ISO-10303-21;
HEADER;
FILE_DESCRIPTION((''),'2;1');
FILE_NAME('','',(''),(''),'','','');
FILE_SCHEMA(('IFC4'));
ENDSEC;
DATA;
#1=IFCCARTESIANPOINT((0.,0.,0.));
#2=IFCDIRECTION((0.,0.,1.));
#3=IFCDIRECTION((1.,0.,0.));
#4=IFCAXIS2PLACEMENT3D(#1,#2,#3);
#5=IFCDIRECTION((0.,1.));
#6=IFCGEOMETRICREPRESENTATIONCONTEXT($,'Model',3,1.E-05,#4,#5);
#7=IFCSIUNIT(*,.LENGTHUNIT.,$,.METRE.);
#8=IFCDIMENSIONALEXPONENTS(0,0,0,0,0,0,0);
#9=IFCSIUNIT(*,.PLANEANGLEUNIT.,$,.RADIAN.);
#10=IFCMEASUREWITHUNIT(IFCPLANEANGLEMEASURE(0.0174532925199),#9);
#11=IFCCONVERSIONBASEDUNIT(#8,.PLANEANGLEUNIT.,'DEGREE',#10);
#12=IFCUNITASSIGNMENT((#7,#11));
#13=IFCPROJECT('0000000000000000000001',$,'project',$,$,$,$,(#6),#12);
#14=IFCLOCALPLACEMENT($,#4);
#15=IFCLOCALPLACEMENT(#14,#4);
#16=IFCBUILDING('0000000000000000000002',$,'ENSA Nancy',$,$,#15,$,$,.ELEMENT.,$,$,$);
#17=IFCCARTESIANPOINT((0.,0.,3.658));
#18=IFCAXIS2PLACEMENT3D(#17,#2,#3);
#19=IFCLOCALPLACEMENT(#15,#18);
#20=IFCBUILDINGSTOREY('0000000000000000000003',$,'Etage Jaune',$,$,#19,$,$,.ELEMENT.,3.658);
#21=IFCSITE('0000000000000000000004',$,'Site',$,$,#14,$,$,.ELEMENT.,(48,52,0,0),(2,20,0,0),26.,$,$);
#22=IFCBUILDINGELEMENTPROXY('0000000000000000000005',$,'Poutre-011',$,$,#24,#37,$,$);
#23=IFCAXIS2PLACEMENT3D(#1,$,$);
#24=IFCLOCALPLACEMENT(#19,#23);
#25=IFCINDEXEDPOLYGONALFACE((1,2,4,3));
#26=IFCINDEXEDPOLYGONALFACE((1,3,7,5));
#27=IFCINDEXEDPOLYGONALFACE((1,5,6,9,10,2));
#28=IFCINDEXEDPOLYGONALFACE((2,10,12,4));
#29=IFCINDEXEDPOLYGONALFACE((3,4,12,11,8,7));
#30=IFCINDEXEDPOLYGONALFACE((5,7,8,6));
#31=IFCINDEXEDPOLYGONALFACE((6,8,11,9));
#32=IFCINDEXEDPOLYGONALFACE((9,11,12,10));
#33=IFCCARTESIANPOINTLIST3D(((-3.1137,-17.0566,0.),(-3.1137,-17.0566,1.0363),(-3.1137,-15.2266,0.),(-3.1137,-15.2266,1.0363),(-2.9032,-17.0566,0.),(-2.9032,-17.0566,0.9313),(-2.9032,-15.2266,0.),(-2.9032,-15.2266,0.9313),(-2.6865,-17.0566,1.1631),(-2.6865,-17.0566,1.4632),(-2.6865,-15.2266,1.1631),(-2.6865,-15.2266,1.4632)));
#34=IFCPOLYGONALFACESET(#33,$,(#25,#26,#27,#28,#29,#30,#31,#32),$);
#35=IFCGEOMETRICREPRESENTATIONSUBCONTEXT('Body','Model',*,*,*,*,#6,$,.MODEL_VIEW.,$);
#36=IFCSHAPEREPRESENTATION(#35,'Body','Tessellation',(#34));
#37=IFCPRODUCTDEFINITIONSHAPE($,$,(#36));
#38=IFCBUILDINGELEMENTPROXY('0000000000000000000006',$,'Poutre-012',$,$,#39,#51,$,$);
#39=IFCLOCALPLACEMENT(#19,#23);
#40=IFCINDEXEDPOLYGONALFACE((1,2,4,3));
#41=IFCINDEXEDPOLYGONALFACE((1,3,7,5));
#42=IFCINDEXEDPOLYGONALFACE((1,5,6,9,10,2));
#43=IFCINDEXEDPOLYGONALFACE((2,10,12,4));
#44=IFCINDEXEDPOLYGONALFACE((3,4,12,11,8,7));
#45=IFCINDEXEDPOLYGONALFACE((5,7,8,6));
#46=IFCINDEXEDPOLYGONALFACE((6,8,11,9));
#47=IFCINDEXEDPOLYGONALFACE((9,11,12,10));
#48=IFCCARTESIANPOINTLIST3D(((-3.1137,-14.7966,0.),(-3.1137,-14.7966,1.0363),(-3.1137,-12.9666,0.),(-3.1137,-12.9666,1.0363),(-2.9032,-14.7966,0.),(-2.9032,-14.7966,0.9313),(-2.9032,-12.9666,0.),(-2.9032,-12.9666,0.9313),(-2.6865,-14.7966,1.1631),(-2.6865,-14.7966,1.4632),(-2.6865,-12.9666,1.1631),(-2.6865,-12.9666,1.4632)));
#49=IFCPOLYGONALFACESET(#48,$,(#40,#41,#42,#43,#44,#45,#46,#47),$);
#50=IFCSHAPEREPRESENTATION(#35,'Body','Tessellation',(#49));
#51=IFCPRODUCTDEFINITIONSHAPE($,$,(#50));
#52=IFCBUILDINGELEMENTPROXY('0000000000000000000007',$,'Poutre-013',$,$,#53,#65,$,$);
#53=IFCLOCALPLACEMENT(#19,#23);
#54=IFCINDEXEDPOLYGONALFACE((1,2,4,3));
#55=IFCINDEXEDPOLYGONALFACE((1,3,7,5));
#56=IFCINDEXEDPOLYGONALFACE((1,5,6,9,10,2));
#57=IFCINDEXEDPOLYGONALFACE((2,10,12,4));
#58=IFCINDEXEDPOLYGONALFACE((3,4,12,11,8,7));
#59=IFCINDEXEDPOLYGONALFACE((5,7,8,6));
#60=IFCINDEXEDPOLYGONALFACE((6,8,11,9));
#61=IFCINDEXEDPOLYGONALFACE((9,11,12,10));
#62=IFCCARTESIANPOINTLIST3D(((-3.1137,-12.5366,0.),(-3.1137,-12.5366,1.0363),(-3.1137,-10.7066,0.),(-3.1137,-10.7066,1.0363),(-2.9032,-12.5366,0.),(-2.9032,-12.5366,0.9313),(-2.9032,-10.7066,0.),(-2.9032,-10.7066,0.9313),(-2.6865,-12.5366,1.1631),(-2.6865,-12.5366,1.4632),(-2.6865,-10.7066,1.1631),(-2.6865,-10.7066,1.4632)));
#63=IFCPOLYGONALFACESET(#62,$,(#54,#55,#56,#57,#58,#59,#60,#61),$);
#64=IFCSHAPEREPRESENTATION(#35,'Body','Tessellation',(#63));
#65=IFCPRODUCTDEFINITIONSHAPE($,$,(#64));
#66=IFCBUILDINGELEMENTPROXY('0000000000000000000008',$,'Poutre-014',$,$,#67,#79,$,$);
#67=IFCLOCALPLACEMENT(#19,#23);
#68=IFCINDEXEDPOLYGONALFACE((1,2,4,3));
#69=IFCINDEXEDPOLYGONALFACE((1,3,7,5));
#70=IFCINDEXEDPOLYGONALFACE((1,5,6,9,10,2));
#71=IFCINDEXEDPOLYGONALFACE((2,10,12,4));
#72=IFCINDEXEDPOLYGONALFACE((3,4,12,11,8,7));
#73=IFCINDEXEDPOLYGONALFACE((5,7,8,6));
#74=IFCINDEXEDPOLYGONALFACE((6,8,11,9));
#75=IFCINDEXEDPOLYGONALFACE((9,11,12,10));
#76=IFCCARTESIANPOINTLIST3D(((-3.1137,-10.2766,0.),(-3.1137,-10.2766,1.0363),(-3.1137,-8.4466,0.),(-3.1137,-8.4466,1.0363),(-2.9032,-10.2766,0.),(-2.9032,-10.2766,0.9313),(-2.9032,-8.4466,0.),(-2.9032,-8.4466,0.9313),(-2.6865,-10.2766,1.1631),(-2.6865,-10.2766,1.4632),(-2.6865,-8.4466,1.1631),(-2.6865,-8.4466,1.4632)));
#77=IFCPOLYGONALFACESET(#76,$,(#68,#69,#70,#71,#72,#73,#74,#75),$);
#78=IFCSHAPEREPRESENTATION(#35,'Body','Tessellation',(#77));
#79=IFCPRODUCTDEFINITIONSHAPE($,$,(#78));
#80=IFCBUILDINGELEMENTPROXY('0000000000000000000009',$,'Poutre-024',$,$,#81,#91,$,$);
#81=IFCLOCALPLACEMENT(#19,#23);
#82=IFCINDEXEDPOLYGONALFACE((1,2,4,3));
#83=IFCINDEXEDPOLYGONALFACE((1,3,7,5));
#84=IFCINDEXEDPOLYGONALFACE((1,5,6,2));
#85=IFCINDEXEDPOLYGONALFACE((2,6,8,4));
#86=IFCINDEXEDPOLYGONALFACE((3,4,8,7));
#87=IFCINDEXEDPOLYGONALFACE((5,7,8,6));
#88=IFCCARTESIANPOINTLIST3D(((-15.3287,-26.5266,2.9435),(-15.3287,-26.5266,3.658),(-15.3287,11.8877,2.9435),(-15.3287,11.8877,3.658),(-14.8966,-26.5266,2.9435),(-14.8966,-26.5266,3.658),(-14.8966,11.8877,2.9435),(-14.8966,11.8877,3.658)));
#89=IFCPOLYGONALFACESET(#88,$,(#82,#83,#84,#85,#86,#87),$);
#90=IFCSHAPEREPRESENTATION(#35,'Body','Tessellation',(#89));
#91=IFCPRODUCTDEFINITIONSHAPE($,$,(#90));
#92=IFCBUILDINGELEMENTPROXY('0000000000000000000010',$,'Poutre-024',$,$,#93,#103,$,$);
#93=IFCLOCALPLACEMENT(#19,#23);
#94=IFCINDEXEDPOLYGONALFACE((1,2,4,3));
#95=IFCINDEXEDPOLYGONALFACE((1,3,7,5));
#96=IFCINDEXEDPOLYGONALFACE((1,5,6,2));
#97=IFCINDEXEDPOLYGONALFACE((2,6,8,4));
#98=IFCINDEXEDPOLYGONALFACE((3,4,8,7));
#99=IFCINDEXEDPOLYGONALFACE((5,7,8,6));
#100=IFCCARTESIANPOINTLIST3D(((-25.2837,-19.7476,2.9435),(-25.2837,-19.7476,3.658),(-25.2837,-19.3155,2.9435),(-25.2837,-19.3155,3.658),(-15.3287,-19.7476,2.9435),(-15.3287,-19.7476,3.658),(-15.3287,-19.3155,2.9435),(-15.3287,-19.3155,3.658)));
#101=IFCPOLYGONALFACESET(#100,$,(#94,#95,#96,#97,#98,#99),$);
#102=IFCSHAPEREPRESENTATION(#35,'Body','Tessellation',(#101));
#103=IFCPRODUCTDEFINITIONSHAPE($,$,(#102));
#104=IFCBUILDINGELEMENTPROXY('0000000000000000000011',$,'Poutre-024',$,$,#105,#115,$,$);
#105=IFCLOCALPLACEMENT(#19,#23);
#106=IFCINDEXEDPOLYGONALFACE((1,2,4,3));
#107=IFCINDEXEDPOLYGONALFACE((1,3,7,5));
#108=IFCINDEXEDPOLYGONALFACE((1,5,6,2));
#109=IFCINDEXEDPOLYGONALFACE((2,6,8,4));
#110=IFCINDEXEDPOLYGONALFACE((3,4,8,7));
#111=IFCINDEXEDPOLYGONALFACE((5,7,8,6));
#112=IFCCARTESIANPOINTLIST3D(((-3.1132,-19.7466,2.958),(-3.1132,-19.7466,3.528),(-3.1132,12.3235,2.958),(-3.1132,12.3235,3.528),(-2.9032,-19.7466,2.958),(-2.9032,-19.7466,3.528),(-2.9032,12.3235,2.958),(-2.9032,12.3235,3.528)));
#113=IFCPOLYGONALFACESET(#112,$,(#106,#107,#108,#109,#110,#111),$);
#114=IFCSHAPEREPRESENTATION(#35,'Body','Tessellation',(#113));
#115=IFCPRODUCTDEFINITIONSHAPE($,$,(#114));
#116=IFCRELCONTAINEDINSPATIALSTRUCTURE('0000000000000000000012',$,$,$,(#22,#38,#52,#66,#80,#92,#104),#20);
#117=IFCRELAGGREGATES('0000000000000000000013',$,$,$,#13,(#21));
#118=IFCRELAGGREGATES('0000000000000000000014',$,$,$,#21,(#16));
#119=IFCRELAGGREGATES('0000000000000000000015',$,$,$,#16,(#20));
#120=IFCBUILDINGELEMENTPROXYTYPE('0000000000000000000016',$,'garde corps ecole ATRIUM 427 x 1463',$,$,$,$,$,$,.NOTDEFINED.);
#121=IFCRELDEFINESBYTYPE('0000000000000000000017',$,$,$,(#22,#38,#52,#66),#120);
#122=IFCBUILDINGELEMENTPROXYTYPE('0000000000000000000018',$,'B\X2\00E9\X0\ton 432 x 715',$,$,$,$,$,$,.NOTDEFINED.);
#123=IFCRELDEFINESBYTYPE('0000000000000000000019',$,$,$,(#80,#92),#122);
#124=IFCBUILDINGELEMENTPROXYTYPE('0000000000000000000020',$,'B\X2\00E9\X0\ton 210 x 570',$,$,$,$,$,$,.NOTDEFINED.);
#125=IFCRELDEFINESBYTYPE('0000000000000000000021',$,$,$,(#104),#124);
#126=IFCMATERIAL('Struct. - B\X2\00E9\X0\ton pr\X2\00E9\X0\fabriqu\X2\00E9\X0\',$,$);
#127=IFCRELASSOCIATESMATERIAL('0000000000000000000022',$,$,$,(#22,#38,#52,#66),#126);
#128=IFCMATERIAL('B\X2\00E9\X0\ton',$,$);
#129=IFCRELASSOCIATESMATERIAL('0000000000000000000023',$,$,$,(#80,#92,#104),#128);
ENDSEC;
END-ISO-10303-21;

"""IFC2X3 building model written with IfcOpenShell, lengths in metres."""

from ifc_helpers import new_model, entity, si_unit, converted_unit, direction, frame, frame_2d, origin_with_axes, place, context, subcontext, project, spatial, polyline, rectangle, outline, extrude, material, type_object, element, save


model = new_model("IFC2X3")

# Units and contexts
model_context = context("Model", 3, precision=1e-05, world=origin_with_axes(), true_north=direction((0.0, 1.0)))
body_context = subcontext(model_context, "Body", "Model", "MODEL_VIEW")
ifc_project = project(units=[si_unit("LENGTHUNIT", "METRE"), converted_unit("PLANEANGLEUNIT", "DEGREE", entity("IfcPlaneAngleMeasure", 0.0174532925199), si_unit("PLANEANGLEUNIT", "RADIAN"), dimensions=[0, 0, 0, 0, 0, 0, 0])], contexts=[model_context])

# Site, building, storey
site_placement = place(None, origin_with_axes())
site = spatial("IfcSite", under=ifc_project, at=site_placement, Name="Site", CompositionType="ELEMENT", RefLatitude=(48, 52, 0, 0), RefLongitude=(2, 20, 0, 0), RefElevation=26.0)
building_placement = place(site_placement, origin_with_axes())
building = spatial("IfcBuilding", under=site, at=building_placement, Name="ENSA Nancy", CompositionType="ELEMENT")
storey_placement = place(building_placement, frame((0.0, 0.0, 3.658), z_axis=(0.0, 0.0, 1.0), x_axis=(1.0, 0.0, 0.0)))
storey = spatial("IfcBuildingStorey", under=building, at=storey_placement, Name="Etage Jaune", CompositionType="ELEMENT", Elevation=3.658)

# Building element proxies
ifc_material_1 = material(Name="Struct. - Béton préfabriqué")
building_element_proxy_type_1 = type_object("IfcBuildingElementProxyType", Name="garde corps ecole ATRIUM 427 x 1463", PredefinedType="NOTDEFINED")
proxy_1_placement = place(storey_placement, frame((-3.1137, -17.0566, 0.0), z_axis=(0.0, 0.0, 1.0), x_axis=(1.0, 0.0, 0.0)))
element("IfcBuildingElementProxy", 1, at=proxy_1_placement, inside=storey, type_object=building_element_proxy_type_1, material=ifc_material_1, Name="Poutre-011", context=body_context, shape_type="SweptSolid", body=[
    extrude(outline(polyline([(0.0, 1.0363), (0.0, 0.0), (0.2105, 0.0), (0.2105, 0.9313), (0.4272, 1.1631), (0.4272, 1.4632), (0.0, 1.0363)])), frame((0.0, 1.83, 0.0), z_axis=(0.0, -1.0, 0.0), x_axis=(1.0, 0.0, 0.0)), (0.0, 0.0, 1.0), 1.83),
])
proxy_2_placement = place(storey_placement, frame((-3.1137, -14.7966, 0.0), z_axis=(0.0, 0.0, 1.0), x_axis=(1.0, 0.0, 0.0)))
element("IfcBuildingElementProxy", 2, at=proxy_2_placement, inside=storey, type_object=building_element_proxy_type_1, material=ifc_material_1, Name="Poutre-012", context=body_context, shape_type="SweptSolid", body=[
    extrude(outline(polyline([(0.0, 1.0363), (0.0, 0.0), (0.2105, 0.0), (0.2105, 0.9313), (0.4272, 1.1631), (0.4272, 1.4632), (0.0, 1.0363)])), frame((0.0, 1.83, 0.0), z_axis=(0.0, -1.0, 0.0), x_axis=(1.0, 0.0, 0.0)), (0.0, 0.0, 1.0), 1.83),
])
proxy_3_placement = place(storey_placement, frame((-3.1137, -12.5366, 0.0), z_axis=(0.0, 0.0, 1.0), x_axis=(1.0, 0.0, 0.0)))
element("IfcBuildingElementProxy", 3, at=proxy_3_placement, inside=storey, type_object=building_element_proxy_type_1, material=ifc_material_1, Name="Poutre-013", context=body_context, shape_type="SweptSolid", body=[
    extrude(outline(polyline([(0.0, 1.0363), (0.0, 0.0), (0.2105, 0.0), (0.2105, 0.9313), (0.4272, 1.1631), (0.4272, 1.4632), (0.0, 1.0363)])), frame((0.0, 1.83, 0.0), z_axis=(0.0, -1.0, 0.0), x_axis=(1.0, 0.0, 0.0)), (0.0, 0.0, 1.0), 1.83),
])
proxy_4_placement = place(storey_placement, frame((-3.1137, -10.2766, 0.0), z_axis=(0.0, 0.0, 1.0), x_axis=(1.0, 0.0, 0.0)))
element("IfcBuildingElementProxy", 4, at=proxy_4_placement, inside=storey, type_object=building_element_proxy_type_1, material=ifc_material_1, Name="Poutre-014", context=body_context, shape_type="SweptSolid", body=[
    extrude(outline(polyline([(0.0, 1.0363), (0.0, 0.0), (0.2105, 0.0), (0.2105, 0.9313), (0.4272, 1.1631), (0.4272, 1.4632), (0.0, 1.0363)])), frame((0.0, 1.83, 0.0), z_axis=(0.0, -1.0, 0.0), x_axis=(1.0, 0.0, 0.0)), (0.0, 0.0, 1.0), 1.83),
])
ifc_material_2 = material(Name="Béton")
building_element_proxy_type_2 = type_object("IfcBuildingElementProxyType", Name="Béton 432 x 715", PredefinedType="NOTDEFINED")
proxy_5_placement = place(storey_placement, frame((-15.1127, -26.5266, 3.658), z_axis=(0.0, 0.0, 1.0), x_axis=(1.0, 0.0, 0.0)))
element("IfcBuildingElementProxy", 5, at=proxy_5_placement, inside=storey, type_object=building_element_proxy_type_2, material=ifc_material_2, Name="Poutre-024", context=body_context, shape_type="SweptSolid", body=[
    extrude(rectangle(XDim=0.7145, YDim=0.4321, at=frame_2d((-0.3573, 0.0), x_axis=(1.0, 0.0))), frame((0.0, 0.0, 0.0), z_axis=(0.0, 1.0, 0.0), x_axis=(0.0, 0.0, 1.0)), (0.0, 0.0, 1.0), 38.4143),
])
proxy_6_placement = place(storey_placement, frame((-15.3287, -19.5316, 3.658), z_axis=(0.0, 0.0, 1.0), x_axis=(0.0, 1.0, 0.0)))
element("IfcBuildingElementProxy", 6, at=proxy_6_placement, inside=storey, type_object=building_element_proxy_type_2, material=ifc_material_2, Name="Poutre-024", context=body_context, shape_type="SweptSolid", body=[
    extrude(rectangle(XDim=0.7145, YDim=0.4321, at=frame_2d((-0.3573, 0.0), x_axis=(1.0, 0.0))), frame((0.0, 0.0, 0.0), z_axis=(0.0, 1.0, 0.0), x_axis=(0.0, 0.0, 1.0)), (0.0, 0.0, 1.0), 9.955),
])
building_element_proxy_type_3 = type_object("IfcBuildingElementProxyType", Name="Béton 210 x 570", PredefinedType="NOTDEFINED")
proxy_7_placement = place(storey_placement, frame((-3.0082, -19.7466, 3.528), z_axis=(0.0, 0.0, 1.0), x_axis=(1.0, 0.0, 0.0)))
element("IfcBuildingElementProxy", 7, at=proxy_7_placement, inside=storey, type_object=building_element_proxy_type_3, material=ifc_material_2, Name="Poutre-024", context=body_context, shape_type="SweptSolid", body=[
    extrude(rectangle(XDim=0.57, YDim=0.21, at=frame_2d((-0.285, 0.0), x_axis=(1.0, 0.0))), frame((0.0, 0.0, 0.0), z_axis=(0.0, 1.0, 0.0), x_axis=(0.0, 0.0, 1.0)), (0.0, 0.0, 1.0), 32.07),
])

save(model, "model.ifc")
